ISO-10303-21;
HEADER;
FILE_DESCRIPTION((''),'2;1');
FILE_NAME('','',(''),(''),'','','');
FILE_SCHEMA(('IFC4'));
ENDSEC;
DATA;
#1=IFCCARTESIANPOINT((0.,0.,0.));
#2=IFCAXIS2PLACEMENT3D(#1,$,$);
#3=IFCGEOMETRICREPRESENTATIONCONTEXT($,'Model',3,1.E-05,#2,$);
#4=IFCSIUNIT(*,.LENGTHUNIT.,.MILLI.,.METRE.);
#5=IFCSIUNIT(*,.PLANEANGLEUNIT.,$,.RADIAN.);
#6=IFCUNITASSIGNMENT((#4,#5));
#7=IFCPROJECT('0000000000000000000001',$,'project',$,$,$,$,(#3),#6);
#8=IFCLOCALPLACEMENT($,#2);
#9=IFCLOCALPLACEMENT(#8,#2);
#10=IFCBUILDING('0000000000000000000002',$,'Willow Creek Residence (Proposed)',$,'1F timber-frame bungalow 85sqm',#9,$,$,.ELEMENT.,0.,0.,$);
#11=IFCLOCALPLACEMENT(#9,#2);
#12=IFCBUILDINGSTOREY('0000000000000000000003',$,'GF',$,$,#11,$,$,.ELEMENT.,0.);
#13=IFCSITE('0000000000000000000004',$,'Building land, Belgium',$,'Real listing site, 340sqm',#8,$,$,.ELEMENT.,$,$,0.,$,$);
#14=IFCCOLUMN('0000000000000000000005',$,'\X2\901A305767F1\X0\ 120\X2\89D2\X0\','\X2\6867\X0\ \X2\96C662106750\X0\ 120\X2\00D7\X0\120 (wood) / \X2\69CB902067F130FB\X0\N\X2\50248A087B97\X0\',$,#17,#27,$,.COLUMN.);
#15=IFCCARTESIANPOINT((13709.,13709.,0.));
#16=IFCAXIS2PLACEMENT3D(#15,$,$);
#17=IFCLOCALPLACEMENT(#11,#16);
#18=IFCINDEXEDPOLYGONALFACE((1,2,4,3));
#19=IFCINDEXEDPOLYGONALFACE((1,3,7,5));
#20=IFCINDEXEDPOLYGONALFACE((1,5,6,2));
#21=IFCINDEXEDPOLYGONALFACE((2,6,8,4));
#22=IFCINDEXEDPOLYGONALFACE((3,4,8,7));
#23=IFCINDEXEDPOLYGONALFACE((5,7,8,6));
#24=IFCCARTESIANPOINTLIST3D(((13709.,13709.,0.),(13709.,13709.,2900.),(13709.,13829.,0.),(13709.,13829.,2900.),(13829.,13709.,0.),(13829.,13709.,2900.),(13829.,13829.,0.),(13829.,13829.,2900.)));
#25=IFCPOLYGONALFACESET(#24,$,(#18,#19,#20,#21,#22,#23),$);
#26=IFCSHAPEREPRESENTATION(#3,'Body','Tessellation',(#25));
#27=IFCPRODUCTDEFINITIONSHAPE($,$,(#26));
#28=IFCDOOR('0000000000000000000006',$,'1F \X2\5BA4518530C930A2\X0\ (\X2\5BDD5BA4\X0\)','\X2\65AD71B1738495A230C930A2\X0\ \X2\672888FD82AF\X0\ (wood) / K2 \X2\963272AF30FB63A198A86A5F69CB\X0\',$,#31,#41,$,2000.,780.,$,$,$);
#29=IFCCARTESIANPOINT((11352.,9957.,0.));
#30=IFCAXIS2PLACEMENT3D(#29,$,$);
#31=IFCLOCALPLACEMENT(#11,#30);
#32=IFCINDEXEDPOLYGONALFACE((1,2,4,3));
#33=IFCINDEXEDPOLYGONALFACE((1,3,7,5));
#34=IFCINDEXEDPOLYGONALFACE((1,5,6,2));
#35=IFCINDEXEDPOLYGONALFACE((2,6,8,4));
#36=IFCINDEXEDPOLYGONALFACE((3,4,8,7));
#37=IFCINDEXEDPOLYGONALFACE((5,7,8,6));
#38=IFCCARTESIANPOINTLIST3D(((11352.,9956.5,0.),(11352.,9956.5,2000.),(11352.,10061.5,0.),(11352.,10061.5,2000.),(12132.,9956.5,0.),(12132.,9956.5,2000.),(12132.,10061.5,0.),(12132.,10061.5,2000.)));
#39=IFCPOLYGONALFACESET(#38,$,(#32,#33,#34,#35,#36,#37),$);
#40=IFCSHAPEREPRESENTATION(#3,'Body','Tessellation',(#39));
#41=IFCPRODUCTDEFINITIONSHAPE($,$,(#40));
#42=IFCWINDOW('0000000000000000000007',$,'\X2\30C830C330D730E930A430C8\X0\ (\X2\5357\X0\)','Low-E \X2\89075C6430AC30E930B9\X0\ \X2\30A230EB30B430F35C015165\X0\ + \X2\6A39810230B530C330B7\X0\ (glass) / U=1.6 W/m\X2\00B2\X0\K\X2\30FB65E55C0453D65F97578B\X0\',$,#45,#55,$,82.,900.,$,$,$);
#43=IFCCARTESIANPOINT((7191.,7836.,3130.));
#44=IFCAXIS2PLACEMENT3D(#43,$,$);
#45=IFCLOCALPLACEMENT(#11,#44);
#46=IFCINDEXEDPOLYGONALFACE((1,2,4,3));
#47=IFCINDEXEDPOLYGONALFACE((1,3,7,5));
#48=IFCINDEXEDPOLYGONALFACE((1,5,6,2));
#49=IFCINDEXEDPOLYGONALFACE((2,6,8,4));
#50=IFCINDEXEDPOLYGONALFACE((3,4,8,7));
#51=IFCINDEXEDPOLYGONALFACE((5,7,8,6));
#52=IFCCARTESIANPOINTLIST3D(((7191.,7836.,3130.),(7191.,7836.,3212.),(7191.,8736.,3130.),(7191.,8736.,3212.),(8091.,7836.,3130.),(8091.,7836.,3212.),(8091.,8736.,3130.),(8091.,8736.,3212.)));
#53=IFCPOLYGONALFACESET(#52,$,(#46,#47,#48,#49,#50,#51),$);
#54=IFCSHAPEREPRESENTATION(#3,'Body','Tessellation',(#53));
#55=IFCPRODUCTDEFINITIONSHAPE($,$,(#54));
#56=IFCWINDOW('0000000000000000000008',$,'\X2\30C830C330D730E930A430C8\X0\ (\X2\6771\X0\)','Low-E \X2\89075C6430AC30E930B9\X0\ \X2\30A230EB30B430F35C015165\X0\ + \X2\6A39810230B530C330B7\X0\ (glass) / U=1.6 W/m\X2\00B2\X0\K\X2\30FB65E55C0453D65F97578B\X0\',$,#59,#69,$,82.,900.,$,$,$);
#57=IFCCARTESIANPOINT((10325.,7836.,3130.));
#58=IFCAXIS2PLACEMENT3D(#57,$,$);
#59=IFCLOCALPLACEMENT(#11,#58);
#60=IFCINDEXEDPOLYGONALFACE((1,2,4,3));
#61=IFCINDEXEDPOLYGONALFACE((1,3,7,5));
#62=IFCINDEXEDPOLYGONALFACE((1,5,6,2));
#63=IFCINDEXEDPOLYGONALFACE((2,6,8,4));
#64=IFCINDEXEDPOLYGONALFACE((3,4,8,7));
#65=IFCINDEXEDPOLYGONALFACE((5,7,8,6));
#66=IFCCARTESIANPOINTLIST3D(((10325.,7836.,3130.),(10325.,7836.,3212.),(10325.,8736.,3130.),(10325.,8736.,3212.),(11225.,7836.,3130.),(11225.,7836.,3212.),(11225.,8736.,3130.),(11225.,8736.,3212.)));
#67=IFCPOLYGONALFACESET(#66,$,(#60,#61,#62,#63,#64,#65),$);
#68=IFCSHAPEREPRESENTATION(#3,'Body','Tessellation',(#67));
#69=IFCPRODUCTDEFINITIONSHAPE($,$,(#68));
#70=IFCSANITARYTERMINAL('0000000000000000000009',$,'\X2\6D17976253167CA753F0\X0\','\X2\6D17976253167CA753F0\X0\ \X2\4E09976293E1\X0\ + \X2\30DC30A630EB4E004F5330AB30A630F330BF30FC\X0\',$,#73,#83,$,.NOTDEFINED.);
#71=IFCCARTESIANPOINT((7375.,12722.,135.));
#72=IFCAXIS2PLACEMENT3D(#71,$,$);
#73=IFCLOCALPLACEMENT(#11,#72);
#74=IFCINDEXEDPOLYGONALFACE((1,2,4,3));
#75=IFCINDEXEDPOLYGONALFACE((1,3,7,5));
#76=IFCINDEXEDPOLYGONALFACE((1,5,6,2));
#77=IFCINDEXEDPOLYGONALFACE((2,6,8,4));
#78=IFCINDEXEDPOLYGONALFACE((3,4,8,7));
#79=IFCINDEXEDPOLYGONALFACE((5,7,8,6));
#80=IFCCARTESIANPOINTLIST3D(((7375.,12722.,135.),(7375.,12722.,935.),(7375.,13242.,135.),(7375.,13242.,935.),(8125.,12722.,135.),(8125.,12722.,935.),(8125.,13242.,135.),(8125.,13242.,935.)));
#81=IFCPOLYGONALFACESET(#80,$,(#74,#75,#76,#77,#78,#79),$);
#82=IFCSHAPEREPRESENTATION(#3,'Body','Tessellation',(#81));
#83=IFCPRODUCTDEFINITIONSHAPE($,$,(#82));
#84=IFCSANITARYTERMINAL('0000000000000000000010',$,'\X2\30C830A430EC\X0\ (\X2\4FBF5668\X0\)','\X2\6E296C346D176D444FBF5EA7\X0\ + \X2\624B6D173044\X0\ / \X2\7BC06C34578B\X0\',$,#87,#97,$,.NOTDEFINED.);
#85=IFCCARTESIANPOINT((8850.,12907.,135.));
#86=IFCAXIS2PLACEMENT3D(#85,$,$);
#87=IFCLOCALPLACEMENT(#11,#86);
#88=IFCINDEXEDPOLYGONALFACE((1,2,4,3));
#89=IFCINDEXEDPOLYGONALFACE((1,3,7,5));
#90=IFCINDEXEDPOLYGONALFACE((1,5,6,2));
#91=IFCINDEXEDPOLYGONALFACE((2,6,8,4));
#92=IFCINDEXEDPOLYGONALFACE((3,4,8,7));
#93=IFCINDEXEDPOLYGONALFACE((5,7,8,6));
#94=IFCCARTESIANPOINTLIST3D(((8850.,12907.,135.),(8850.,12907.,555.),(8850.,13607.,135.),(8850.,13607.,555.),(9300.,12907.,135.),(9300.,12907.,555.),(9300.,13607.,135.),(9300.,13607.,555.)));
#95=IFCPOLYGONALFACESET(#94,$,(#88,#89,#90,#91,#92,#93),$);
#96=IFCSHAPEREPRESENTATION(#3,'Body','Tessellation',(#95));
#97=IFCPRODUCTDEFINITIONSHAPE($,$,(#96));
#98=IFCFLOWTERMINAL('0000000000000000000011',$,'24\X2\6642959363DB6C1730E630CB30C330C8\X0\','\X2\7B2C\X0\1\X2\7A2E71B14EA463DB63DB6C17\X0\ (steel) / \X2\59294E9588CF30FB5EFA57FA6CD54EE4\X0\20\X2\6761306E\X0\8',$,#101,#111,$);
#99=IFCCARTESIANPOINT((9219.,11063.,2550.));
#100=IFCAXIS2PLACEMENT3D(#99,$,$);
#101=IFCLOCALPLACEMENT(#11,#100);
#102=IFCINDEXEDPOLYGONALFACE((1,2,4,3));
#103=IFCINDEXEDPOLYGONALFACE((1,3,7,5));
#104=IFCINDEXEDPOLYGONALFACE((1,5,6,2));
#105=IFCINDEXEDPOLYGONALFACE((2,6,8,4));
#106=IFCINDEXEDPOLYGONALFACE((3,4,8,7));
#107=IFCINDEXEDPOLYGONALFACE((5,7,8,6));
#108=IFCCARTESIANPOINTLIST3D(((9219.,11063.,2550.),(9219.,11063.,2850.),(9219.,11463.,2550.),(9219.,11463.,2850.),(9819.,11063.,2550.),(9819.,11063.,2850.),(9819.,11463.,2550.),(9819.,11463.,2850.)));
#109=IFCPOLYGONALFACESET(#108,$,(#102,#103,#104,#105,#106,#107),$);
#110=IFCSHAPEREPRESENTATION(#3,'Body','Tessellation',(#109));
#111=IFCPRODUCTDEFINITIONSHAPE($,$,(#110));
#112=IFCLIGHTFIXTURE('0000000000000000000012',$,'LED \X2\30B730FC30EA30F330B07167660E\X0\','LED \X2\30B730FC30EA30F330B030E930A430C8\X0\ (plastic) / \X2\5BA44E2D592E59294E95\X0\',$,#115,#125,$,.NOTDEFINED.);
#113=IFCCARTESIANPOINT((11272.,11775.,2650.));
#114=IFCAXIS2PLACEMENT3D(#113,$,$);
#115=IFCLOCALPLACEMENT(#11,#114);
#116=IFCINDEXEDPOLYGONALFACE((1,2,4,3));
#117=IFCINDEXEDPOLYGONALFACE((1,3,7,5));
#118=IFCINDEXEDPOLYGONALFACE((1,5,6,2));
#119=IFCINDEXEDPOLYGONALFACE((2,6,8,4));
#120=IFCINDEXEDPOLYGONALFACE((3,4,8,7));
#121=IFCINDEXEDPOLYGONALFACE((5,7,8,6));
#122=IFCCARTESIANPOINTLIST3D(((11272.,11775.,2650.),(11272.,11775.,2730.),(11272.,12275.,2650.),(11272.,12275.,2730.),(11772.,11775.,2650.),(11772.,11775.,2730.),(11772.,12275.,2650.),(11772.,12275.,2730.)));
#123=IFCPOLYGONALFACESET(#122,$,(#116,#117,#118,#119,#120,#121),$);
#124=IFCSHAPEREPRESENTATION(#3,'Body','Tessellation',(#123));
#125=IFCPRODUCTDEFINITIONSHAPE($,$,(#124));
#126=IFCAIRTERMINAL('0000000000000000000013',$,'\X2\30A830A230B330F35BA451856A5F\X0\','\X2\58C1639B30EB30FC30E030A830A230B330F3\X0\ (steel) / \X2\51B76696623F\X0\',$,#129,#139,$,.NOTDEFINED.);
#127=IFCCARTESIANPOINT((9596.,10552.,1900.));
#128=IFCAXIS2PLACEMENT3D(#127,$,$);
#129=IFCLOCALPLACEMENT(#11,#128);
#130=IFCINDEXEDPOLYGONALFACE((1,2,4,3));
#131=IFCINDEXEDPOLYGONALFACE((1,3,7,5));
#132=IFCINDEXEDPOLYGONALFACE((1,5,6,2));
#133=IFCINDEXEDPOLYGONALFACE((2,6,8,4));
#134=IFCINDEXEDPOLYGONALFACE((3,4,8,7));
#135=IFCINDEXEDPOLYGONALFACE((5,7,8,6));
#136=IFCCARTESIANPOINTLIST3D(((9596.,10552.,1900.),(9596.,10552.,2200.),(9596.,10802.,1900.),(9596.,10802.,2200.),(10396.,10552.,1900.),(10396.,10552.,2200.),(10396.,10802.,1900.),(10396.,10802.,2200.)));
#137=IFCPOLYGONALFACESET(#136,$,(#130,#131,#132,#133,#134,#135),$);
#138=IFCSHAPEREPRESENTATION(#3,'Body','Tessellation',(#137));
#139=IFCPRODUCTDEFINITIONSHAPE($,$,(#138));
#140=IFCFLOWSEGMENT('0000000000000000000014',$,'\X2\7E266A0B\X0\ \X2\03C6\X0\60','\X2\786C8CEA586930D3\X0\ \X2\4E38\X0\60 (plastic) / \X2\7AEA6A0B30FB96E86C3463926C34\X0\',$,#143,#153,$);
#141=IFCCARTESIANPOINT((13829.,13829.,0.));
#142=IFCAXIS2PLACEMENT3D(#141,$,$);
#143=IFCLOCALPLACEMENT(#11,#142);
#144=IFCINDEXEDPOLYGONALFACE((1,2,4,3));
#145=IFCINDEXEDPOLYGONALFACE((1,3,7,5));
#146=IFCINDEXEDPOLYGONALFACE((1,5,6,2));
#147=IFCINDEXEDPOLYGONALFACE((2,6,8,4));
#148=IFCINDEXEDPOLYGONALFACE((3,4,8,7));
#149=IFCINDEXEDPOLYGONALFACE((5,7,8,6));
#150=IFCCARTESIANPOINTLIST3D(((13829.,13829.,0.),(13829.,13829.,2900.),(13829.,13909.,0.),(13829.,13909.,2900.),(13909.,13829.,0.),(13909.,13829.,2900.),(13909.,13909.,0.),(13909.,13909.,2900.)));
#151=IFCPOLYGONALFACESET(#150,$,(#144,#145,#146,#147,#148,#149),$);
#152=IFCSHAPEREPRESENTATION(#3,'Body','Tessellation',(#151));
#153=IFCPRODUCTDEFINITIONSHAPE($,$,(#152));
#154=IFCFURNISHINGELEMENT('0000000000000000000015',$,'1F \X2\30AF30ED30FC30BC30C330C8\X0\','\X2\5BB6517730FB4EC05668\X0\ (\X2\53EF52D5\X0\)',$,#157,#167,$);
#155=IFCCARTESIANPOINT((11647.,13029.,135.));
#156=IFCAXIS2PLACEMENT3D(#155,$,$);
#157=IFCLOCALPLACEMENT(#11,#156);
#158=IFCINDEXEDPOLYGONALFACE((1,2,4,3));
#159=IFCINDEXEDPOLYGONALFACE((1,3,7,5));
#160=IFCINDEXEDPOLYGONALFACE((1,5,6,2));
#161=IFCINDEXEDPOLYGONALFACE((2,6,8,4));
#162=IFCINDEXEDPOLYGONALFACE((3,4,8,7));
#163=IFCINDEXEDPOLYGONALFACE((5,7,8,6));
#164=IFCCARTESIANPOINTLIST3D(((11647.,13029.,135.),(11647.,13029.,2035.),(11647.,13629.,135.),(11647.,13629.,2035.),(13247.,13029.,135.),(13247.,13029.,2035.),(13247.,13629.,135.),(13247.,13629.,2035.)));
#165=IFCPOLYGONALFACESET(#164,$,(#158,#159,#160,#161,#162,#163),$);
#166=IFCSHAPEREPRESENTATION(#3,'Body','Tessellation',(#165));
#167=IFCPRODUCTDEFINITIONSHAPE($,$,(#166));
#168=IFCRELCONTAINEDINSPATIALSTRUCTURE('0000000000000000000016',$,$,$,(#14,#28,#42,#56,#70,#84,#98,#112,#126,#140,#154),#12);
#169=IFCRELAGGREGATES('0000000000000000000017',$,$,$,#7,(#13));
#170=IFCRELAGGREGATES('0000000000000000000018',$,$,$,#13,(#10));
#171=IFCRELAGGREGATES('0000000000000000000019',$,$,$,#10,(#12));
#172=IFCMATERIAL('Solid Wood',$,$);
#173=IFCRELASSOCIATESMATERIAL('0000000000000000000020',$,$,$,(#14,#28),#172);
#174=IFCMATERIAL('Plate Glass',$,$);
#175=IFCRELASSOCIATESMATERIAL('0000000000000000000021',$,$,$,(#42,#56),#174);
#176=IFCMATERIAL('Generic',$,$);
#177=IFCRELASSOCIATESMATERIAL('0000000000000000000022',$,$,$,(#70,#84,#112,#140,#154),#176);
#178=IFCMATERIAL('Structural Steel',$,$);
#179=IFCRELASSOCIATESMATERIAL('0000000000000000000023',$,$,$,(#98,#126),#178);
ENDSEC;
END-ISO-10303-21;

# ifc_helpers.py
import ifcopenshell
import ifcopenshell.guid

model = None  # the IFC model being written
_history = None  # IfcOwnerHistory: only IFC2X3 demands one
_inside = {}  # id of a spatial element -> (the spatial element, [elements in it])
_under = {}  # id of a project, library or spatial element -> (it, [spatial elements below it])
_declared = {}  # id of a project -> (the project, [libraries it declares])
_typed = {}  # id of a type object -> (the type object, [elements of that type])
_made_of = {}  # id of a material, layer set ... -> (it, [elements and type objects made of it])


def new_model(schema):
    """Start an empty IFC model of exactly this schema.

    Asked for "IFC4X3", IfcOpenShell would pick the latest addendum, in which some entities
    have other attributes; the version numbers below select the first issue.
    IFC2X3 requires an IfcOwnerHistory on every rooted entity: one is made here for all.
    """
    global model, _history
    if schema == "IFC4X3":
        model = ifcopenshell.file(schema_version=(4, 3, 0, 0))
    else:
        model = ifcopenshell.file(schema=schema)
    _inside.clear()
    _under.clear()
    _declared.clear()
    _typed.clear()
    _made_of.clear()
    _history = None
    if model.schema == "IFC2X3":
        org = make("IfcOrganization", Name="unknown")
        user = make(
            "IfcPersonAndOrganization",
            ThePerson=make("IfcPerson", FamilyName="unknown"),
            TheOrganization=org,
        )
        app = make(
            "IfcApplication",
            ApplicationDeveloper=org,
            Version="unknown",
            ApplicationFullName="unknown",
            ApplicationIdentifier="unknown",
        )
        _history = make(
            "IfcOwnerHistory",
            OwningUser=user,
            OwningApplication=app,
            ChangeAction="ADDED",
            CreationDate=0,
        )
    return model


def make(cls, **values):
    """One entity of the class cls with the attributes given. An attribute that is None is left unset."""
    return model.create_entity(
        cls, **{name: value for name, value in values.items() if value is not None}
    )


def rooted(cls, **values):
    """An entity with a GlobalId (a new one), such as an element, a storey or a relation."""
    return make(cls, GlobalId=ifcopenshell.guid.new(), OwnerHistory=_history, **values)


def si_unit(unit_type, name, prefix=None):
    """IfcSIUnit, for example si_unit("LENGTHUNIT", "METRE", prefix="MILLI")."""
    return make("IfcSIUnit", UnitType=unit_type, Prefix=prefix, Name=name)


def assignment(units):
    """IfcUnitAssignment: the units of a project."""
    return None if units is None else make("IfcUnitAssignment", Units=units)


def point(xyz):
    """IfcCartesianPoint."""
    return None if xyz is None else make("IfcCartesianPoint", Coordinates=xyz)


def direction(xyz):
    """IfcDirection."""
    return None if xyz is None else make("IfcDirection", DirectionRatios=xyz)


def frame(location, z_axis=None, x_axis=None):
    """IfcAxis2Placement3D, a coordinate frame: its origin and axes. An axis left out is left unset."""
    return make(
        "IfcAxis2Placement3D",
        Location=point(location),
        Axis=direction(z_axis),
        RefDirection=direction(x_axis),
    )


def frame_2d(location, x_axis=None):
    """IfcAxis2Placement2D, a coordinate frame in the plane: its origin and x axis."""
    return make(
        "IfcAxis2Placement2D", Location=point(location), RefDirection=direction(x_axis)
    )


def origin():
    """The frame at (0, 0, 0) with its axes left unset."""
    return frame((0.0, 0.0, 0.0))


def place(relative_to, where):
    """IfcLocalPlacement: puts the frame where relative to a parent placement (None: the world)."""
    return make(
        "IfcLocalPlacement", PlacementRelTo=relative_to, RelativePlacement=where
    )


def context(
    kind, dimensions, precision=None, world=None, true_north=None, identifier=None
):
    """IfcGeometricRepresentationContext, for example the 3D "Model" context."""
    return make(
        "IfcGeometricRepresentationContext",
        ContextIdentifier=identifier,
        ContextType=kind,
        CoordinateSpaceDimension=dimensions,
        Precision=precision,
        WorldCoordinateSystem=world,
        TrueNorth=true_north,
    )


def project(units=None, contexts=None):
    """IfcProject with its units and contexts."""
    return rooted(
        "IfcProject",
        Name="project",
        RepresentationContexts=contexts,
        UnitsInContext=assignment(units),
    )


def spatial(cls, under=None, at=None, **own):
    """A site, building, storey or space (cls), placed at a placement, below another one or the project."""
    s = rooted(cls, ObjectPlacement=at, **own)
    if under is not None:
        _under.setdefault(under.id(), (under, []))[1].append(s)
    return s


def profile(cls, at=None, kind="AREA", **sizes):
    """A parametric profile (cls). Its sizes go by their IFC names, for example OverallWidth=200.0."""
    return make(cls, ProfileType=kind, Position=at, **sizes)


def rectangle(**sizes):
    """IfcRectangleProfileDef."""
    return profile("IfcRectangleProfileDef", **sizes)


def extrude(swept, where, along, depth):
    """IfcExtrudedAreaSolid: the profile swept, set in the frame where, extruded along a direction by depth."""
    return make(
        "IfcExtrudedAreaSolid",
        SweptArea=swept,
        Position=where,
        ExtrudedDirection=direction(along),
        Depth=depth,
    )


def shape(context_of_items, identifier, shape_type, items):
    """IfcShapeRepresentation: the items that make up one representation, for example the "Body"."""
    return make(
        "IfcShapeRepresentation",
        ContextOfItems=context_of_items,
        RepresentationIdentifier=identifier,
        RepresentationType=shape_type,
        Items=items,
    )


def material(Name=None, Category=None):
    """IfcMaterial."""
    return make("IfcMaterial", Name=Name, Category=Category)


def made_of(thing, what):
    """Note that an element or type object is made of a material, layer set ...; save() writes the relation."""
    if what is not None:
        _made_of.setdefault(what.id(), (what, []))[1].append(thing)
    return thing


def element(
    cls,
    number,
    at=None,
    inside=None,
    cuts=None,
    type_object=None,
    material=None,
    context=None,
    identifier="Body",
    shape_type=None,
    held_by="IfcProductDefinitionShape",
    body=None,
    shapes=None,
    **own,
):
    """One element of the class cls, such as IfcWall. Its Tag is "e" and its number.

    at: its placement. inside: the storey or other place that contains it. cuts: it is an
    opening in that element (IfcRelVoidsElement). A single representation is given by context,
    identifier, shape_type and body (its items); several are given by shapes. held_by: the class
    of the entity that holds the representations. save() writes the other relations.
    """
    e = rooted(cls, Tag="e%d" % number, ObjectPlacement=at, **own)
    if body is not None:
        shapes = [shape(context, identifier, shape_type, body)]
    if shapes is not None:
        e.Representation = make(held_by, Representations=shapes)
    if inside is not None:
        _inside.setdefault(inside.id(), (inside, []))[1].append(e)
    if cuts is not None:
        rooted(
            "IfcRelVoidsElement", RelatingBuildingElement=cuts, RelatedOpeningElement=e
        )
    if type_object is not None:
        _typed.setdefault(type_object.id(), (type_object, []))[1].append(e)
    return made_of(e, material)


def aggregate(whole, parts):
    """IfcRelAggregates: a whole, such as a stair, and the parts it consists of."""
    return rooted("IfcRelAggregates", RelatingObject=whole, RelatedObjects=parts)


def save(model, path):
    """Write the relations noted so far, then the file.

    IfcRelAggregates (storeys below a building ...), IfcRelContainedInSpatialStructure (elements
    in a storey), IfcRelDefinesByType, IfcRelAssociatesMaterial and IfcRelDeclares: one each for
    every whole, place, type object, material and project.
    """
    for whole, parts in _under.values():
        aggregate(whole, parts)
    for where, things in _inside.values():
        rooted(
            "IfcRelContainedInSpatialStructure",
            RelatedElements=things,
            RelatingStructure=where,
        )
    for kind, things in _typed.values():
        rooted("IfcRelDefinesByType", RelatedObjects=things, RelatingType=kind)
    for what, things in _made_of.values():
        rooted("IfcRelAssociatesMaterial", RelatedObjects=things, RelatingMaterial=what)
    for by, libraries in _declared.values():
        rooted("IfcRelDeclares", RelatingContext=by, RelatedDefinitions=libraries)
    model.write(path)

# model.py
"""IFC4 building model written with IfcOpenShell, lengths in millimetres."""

from ifc_helpers import new_model, si_unit, frame, frame_2d, origin, place, context, project, spatial, rectangle, extrude, material, element, save


model = new_model("IFC4")

# Units and contexts
model_context = context("Model", 3, precision=1e-05, world=origin())
ifc_project = project(units=[si_unit("LENGTHUNIT", "METRE", prefix="MILLI"), si_unit("PLANEANGLEUNIT", "RADIAN")], contexts=[model_context])

# Site, building, storey
site_placement = place(None, origin())
site = spatial("IfcSite", under=ifc_project, at=site_placement, Name="Building land, Belgium", ObjectType="Real listing site, 340sqm", CompositionType="ELEMENT", RefElevation=0.0)
building_placement = place(site_placement, origin())
building = spatial("IfcBuilding", under=site, at=building_placement, Name="Willow Creek Residence (Proposed)", ObjectType="1F timber-frame bungalow 85sqm", CompositionType="ELEMENT", ElevationOfRefHeight=0.0, ElevationOfTerrain=0.0)
storey_placement = place(building_placement, origin())
storey = spatial("IfcBuildingStorey", under=building, at=storey_placement, Name="GF", CompositionType="ELEMENT", Elevation=0.0)

# Column
ifc_material_1 = material(Name="Solid Wood")
column_1_placement = place(storey_placement, frame((13709.0, 13709.0, 0.0)))
element("IfcColumn", 1, at=column_1_placement, inside=storey, material=ifc_material_1, Name="通し柱 120角", Description="桧 集成材 120×120 (wood) / 構造柱・N値計算", PredefinedType="COLUMN", context=model_context, shape_type="SweptSolid", body=[
    extrude(rectangle(XDim=120.0, YDim=120.0, at=frame_2d((60.0, 60.0))), frame((13709.0, 13709.0, 0.0)), (0.0, 0.0, 1.0), 2900.0),
])

# Door
door_placement = place(storey_placement, frame((11352.0, 9957.0, 0.0)))
element("IfcDoor", 2, at=door_placement, inside=storey, material=ifc_material_1, Name="1F 室内ドア (寝室)", Description="断熱玄関ドア 木製芯 (wood) / K2 防犯・採風機構", OverallHeight=2000.0, OverallWidth=780.0, context=model_context, shape_type="SweptSolid", body=[
    extrude(rectangle(XDim=780.0, YDim=105.0, at=frame_2d((390.0, 52.0))), frame((11352.0, 9957.0, 0.0)), (0.0, 0.0, 1.0), 2000.0),
])

# Windows
ifc_material_2 = material(Name="Plate Glass")
window_1_placement = place(storey_placement, frame((7191.0, 7836.0, 3130.0)))
element("IfcWindow", 3, at=window_1_placement, inside=storey, material=ifc_material_2, Name="トップライト (南)", Description="Low-E 複層ガラス アルゴン封入 + 樹脂サッシ (glass) / U=1.6 W/m²K・日射取得型", OverallHeight=82.0, OverallWidth=900.0, context=model_context, shape_type="SweptSolid", body=[
    extrude(rectangle(XDim=900.0, YDim=900.0, at=frame_2d((450.0, 450.0))), frame((7191.0, 7836.0, 3130.0)), (0.0, 0.0, 1.0), 82.0),
])
window_2_placement = place(storey_placement, frame((10325.0, 7836.0, 3130.0)))
element("IfcWindow", 4, at=window_2_placement, inside=storey, material=ifc_material_2, Name="トップライト (東)", Description="Low-E 複層ガラス アルゴン封入 + 樹脂サッシ (glass) / U=1.6 W/m²K・日射取得型", OverallHeight=82.0, OverallWidth=900.0, context=model_context, shape_type="SweptSolid", body=[
    extrude(rectangle(XDim=900.0, YDim=900.0, at=frame_2d((450.0, 450.0))), frame((10325.0, 7836.0, 3130.0)), (0.0, 0.0, 1.0), 82.0),
])

# Sanitary terminals
ifc_material_3 = material(Name="Generic")
sanitary_terminal_1_placement = place(storey_placement, frame((7375.0, 12722.0, 135.0)))
element("IfcSanitaryTerminal", 5, at=sanitary_terminal_1_placement, inside=storey, material=ifc_material_3, Name="洗面化粧台", Description="洗面化粧台 三面鏡 + ボウル一体カウンター", PredefinedType="NOTDEFINED", context=model_context, shape_type="SweptSolid", body=[
    extrude(rectangle(XDim=750.0, YDim=520.0, at=frame_2d((375.0, 260.0))), frame((7375.0, 12722.0, 135.0)), (0.0, 0.0, 1.0), 800.0),
])
sanitary_terminal_2_placement = place(storey_placement, frame((8850.0, 12907.0, 135.0)))
element("IfcSanitaryTerminal", 6, at=sanitary_terminal_2_placement, inside=storey, material=ifc_material_3, Name="トイレ (便器)", Description="温水洗浄便座 + 手洗い / 節水型", PredefinedType="NOTDEFINED", context=model_context, shape_type="SweptSolid", body=[
    extrude(rectangle(XDim=450.0, YDim=700.0, at=frame_2d((225.0, 350.0))), frame((8850.0, 12907.0, 135.0)), (0.0, 0.0, 1.0), 420.0),
])

# Flow terminal
ifc_material_4 = material(Name="Structural Steel")
flow_terminal_placement = place(storey_placement, frame((9219.0, 11063.0, 2550.0)))
element("IfcFlowTerminal", 7, at=flow_terminal_placement, inside=storey, material=ifc_material_4, Name="24時間換気ユニット", Description="第1種熱交換換気 (steel) / 天井裏・建基法令20条の8", context=model_context, shape_type="SweptSolid", body=[
    extrude(rectangle(XDim=600.0, YDim=400.0, at=frame_2d((300.0, 200.0))), frame((9219.0, 11063.0, 2550.0)), (0.0, 0.0, 1.0), 300.0),
])

# Light fixture
light_fixture_placement = place(storey_placement, frame((11272.0, 11775.0, 2650.0)))
element("IfcLightFixture", 8, at=light_fixture_placement, inside=storey, material=ifc_material_3, Name="LED シーリング照明", Description="LED シーリングライト (plastic) / 室中央天井", PredefinedType="NOTDEFINED", context=model_context, shape_type="SweptSolid", body=[
    extrude(rectangle(XDim=500.0, YDim=500.0, at=frame_2d((250.0, 250.0))), frame((11272.0, 11775.0, 2650.0)), (0.0, 0.0, 1.0), 80.0),
])

# Air terminal
air_terminal_placement = place(storey_placement, frame((9596.0, 10552.0, 1900.0)))
element("IfcAirTerminal", 9, at=air_terminal_placement, inside=storey, material=ifc_material_4, Name="エアコン室内機", Description="壁掛ルームエアコン (steel) / 冷暖房", PredefinedType="NOTDEFINED", context=model_context, shape_type="SweptSolid", body=[
    extrude(rectangle(XDim=800.0, YDim=250.0, at=frame_2d((400.0, 125.0))), frame((9596.0, 10552.0, 1900.0)), (0.0, 0.0, 1.0), 300.0),
])

# Flow segment
flow_segment_placement = place(storey_placement, frame((13829.0, 13829.0, 0.0)))
element("IfcFlowSegment", 10, at=flow_segment_placement, inside=storey, material=ifc_material_3, Name="縦樋 φ60", Description="硬質塩ビ 丸60 (plastic) / 竪樋・雨水排水", context=model_context, shape_type="SweptSolid", body=[
    extrude(rectangle(XDim=80.0, YDim=80.0, at=frame_2d((40.0, 40.0))), frame((13829.0, 13829.0, 0.0)), (0.0, 0.0, 1.0), 2900.0),
])

# Furnishing element
furnishing_placement = place(storey_placement, frame((11647.0, 13029.0, 135.0)))
element("IfcFurnishingElement", 11, at=furnishing_placement, inside=storey, material=ifc_material_3, Name="1F クローゼット", Description="家具・什器 (可動)", context=model_context, shape_type="SweptSolid", body=[
    extrude(rectangle(XDim=1600.0, YDim=600.0, at=frame_2d((800.0, 300.0))), frame((11647.0, 13029.0, 135.0)), (0.0, 0.0, 1.0), 1900.0),
])

save(model, "model.ifc")
